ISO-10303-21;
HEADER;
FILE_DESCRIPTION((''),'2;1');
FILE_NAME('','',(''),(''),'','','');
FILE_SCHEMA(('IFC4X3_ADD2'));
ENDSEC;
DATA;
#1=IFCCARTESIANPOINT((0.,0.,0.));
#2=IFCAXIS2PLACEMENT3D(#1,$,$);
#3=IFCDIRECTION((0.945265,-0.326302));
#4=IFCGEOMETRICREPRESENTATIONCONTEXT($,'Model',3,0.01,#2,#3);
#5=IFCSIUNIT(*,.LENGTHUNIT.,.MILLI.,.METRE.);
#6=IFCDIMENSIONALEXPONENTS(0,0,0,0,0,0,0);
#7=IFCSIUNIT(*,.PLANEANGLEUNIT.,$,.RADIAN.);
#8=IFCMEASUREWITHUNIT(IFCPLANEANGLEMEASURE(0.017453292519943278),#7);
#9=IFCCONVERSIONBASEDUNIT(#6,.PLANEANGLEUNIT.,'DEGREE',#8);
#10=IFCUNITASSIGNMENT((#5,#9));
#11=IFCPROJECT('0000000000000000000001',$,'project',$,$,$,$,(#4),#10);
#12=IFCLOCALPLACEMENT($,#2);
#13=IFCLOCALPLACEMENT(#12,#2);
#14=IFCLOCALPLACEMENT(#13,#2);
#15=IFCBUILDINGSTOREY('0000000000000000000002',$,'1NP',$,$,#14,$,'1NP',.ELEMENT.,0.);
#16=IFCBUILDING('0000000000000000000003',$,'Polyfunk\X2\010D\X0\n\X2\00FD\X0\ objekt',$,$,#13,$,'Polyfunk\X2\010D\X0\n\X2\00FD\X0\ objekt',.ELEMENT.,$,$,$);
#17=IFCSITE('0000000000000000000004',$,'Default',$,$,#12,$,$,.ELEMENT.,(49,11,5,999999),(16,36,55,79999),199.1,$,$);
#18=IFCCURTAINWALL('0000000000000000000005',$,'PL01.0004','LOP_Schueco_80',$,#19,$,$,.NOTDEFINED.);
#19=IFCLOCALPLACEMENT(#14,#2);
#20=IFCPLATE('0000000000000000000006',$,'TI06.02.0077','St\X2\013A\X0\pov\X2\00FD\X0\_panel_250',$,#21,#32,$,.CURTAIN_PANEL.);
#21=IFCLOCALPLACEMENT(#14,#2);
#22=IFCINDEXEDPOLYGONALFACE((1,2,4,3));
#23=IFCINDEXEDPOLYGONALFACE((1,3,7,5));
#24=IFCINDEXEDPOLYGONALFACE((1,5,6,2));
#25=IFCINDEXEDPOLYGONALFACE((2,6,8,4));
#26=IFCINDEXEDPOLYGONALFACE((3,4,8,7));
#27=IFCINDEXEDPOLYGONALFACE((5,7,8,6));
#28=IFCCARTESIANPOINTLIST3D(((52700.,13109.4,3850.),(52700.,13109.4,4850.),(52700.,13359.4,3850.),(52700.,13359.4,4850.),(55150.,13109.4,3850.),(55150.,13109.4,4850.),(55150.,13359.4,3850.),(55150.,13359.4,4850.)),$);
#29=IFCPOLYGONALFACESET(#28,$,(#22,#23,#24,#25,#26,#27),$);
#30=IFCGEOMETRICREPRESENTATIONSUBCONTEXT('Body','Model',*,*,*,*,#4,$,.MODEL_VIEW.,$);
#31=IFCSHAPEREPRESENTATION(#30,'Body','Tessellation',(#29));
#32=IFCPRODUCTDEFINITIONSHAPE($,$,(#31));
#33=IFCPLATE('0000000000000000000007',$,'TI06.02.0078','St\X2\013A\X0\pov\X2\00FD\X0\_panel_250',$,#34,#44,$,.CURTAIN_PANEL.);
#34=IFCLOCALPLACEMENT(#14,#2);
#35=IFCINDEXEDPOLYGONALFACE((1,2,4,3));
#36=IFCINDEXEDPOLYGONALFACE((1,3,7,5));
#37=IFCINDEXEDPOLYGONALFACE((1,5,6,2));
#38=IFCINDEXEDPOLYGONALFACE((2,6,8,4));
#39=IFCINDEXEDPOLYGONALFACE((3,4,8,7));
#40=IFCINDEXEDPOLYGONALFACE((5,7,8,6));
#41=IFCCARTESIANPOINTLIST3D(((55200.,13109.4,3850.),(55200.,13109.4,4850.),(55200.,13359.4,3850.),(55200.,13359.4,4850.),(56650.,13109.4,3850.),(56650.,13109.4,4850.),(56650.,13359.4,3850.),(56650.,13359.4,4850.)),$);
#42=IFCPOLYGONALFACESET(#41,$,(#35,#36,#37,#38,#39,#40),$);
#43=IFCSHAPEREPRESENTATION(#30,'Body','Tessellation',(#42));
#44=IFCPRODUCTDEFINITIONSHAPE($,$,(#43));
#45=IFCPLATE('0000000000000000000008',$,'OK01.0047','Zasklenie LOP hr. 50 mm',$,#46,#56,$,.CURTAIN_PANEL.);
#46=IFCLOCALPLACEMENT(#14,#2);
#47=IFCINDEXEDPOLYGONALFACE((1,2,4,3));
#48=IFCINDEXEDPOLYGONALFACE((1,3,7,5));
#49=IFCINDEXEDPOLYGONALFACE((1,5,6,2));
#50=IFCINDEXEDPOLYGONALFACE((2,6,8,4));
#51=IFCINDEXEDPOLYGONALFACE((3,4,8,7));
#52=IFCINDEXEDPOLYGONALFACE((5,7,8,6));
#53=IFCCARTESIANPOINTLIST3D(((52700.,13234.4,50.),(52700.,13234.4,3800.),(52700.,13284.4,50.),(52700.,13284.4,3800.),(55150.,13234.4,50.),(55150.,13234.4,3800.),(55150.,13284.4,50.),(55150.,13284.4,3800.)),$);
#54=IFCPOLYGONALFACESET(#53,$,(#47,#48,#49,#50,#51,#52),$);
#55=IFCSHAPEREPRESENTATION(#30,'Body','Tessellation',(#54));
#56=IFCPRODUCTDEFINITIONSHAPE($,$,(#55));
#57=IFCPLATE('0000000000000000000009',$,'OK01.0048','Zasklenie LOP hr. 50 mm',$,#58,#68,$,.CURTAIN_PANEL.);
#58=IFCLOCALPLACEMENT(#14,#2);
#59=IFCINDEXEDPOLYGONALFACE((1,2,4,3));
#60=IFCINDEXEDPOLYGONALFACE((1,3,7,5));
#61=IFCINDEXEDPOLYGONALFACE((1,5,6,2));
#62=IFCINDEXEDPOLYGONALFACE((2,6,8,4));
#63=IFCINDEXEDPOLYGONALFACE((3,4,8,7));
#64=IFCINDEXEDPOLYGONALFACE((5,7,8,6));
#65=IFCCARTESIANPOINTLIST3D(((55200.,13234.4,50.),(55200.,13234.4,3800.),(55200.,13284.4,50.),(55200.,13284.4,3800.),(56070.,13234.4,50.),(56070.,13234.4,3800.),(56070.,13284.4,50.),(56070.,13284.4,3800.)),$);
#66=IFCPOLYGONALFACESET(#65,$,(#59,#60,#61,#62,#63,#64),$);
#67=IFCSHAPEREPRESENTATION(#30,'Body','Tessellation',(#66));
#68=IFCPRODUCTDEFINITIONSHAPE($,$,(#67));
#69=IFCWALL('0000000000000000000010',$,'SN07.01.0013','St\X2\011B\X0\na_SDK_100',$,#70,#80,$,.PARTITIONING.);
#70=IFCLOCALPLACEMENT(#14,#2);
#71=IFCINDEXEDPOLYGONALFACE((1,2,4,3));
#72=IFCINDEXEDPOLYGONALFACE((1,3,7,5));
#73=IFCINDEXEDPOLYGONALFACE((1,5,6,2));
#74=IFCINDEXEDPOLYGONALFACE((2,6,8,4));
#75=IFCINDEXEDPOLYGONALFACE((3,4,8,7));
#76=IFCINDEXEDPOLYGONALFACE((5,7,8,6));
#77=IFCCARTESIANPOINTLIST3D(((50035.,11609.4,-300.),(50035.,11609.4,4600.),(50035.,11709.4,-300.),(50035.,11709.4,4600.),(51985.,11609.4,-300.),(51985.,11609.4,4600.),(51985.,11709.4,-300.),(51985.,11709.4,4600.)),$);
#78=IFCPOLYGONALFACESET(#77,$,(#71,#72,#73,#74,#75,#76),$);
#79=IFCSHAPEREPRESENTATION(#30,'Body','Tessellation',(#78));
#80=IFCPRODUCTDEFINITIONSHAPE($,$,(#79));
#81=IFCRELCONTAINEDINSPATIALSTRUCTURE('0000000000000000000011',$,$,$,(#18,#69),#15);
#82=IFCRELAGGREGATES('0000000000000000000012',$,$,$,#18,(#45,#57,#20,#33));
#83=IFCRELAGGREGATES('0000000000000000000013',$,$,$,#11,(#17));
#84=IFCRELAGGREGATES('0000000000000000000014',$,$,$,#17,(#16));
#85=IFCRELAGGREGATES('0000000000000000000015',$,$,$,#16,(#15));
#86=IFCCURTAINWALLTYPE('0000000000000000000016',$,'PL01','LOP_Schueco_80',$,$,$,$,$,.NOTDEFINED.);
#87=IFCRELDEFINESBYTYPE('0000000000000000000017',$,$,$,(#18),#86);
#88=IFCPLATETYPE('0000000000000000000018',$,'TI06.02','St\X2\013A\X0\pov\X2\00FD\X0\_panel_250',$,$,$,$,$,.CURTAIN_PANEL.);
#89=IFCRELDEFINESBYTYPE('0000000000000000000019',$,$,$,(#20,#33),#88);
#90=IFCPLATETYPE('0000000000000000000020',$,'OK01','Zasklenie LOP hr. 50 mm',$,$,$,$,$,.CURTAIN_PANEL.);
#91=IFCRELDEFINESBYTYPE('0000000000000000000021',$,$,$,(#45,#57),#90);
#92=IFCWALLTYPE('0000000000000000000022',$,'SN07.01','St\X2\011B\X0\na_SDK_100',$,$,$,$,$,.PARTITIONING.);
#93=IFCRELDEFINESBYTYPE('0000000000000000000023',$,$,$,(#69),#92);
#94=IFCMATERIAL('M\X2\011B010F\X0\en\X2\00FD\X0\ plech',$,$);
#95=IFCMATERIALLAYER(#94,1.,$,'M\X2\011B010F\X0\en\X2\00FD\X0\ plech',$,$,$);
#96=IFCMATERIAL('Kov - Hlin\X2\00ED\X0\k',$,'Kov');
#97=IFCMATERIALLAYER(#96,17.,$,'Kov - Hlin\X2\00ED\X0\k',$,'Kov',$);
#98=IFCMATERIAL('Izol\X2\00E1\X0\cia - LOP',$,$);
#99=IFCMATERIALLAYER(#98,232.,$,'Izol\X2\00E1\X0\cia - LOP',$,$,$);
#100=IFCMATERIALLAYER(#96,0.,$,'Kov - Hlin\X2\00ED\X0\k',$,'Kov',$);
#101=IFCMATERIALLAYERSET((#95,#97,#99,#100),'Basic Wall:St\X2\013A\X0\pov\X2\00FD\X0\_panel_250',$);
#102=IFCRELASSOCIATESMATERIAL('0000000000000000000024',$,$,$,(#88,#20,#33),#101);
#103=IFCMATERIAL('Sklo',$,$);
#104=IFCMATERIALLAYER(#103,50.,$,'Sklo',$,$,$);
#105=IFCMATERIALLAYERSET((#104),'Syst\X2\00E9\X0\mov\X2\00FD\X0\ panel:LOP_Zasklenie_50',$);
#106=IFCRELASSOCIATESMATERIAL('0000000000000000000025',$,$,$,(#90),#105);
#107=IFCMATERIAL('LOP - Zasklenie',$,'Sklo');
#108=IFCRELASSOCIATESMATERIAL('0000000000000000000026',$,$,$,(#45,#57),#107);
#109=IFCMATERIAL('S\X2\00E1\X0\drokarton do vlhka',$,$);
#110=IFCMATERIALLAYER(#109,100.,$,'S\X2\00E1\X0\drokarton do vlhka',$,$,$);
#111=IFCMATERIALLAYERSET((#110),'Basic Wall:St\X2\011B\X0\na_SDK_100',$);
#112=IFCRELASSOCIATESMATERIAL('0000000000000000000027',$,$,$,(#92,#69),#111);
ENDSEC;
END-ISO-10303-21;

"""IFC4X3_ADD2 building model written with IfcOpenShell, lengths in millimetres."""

from ifc_helpers import new_model, entity, si_unit, converted_unit, direction, frame, frame_2d, origin, origin_2d_with_axis, place, context, subcontext, project, spatial, polyline, rectangle, extrude, clip, bounded_halfspace, source, transform, mapped, material, layer, layer_set, layer_usage, type_object, type_shapes, element, aggregate, save


model = new_model("IFC4X3_ADD2")

# Units and contexts
model_context = context("Model", 3, precision=0.01, world=origin(), true_north=direction((0.945265, -0.326302)))
body_context = subcontext(model_context, "Body", "Model", "MODEL_VIEW")
ifc_project = project(units=[si_unit("LENGTHUNIT", "METRE", prefix="MILLI"), converted_unit("PLANEANGLEUNIT", "DEGREE", entity("IfcPlaneAngleMeasure", 0.017453292519943278), si_unit("PLANEANGLEUNIT", "RADIAN"), dimensions=[0, 0, 0, 0, 0, 0, 0])], contexts=[model_context])

# Site, building, storey
site_placement = place(None, origin())
site = spatial("IfcSite", under=ifc_project, at=site_placement, Name="Default", CompositionType="ELEMENT", RefLatitude=(49, 11, 5, 999999), RefLongitude=(16, 36, 55, 79999), RefElevation=199.1)
building_placement = place(site_placement, origin())
building = spatial("IfcBuilding", under=site, at=building_placement, Name="Polyfunkčný objekt", LongName="Polyfunkčný objekt", CompositionType="ELEMENT")
storey_placement = place(building_placement, origin())
storey = spatial("IfcBuildingStorey", under=building, at=storey_placement, Name="1NP", LongName="1NP", CompositionType="ELEMENT", Elevation=0.0)

# Curtain wall, plates
curtain_wall_type = type_object("IfcCurtainWallType", Name="PL01", Description="LOP_Schueco_80", PredefinedType="NOTDEFINED")
curtain_wall_placement = place(storey_placement, origin())
curtain_wall = element("IfcCurtainWall", 1, at=curtain_wall_placement, inside=storey, type_object=curtain_wall_type, Name="PL01.0004", Description="LOP_Schueco_80", PredefinedType="NOTDEFINED")
ifc_material_1 = material(Name="Měďený plech")
ifc_layer_1 = layer(ifc_material_1, 1.0, Name="Měďený plech")
ifc_material_2 = material(Name="Kov - Hliník", Category="Kov")
ifc_layer_2 = layer(ifc_material_2, 17.0, Name="Kov - Hliník", Category="Kov")
ifc_material_3 = material(Name="Izolácia - LOP")
ifc_layer_3 = layer(ifc_material_3, 232.0, Name="Izolácia - LOP")
ifc_layer_4 = layer(ifc_material_2, 0.0, Name="Kov - Hliník", Category="Kov")
ifc_layer_set_1 = layer_set([ifc_layer_1, ifc_layer_2, ifc_layer_3, ifc_layer_4], Name="Basic Wall:Stĺpový_panel_250")
ifc_layer_usage_1 = layer_usage(ifc_layer_set_1, "AXIS2", "NEGATIVE", 125.0)
plate_type_1 = type_object("IfcPlateType", Name="TI06.02", Description="Stĺpový_panel_250", PredefinedType="CURTAIN_PANEL", material=ifc_layer_set_1)
plate_1_placement = place(storey_placement, frame((52700.0, 13234.4, 3850.0)))
plate_1 = element("IfcPlate", 2, at=plate_1_placement, type_object=plate_type_1, material=ifc_layer_usage_1, Name="TI06.02.0077", Description="Stĺpový_panel_250", PredefinedType="CURTAIN_PANEL", context=body_context, shape_type="SweptSolid", body=[
    extrude(rectangle(XDim=250.0, YDim=2450.0, at=origin_2d_with_axis()), frame((1225.0, 0.0, 0.0), z_axis=(0.0, 0.0, 1.0), x_axis=(0.0, 1.0, 0.0)), (0.0, 0.0, 1.0), 1000.0),
])
ifc_layer_usage_2 = layer_usage(ifc_layer_set_1, "AXIS2", "NEGATIVE", 125.0)
plate_2_placement = place(storey_placement, frame((55200.0, 13234.4, 3850.0)))
plate_2 = element("IfcPlate", 3, at=plate_2_placement, type_object=plate_type_1, material=ifc_layer_usage_2, Name="TI06.02.0078", Description="Stĺpový_panel_250", PredefinedType="CURTAIN_PANEL", context=body_context, shape_type="SweptSolid", body=[
    extrude(rectangle(XDim=250.0, YDim=1450.0, at=origin_2d_with_axis()), frame((725.0, 0.0, 0.0), z_axis=(0.0, 0.0, 1.0), x_axis=(0.0, 1.0, 0.0)), (0.0, 0.0, 1.0), 1000.0),
])
ifc_material_4 = material(Name="LOP - Zasklenie", Category="Sklo")
ifc_material_5 = material(Name="Sklo")
ifc_layer_5 = layer(ifc_material_5, 50.0, Name="Sklo")
ifc_layer_set_2 = layer_set([ifc_layer_5], Name="Systémový panel:LOP_Zasklenie_50")
plate_type_2 = type_object("IfcPlateType", Name="OK01", Description="Zasklenie LOP hr. 50 mm", PredefinedType="CURTAIN_PANEL", material=ifc_layer_set_2)
shared_shape_1 = source(origin(), body_context, "Body", "SweptSolid", [
    extrude(rectangle(XDim=3750.0, YDim=2450.0, at=frame_2d((-141.7, 0.0), x_axis=(1.0, 0.0))), frame((0.0, 0.0, 2016.7), z_axis=(0.0, 1.0, 0.0), x_axis=(0.0, 0.0, 1.0)), (0.0, 0.0, 1.0), 50.0),
])
plate_3_placement = place(curtain_wall_placement, frame((53925.0, 13234.4, 50.0)))
plate_3 = element("IfcPlate", 4, at=plate_3_placement, type_object=plate_type_2, material=ifc_material_4, Name="OK01.0047", Description="Zasklenie LOP hr. 50 mm", PredefinedType="CURTAIN_PANEL", context=body_context, shape_type="MappedRepresentation", body=[
    mapped(shared_shape_1, transform((0.0, 0.0, 0.0), scale=1.0)),
])
shared_shape_2 = source(origin(), body_context, "Body", "SweptSolid", [
    extrude(rectangle(XDim=3750.0, YDim=870.0, at=frame_2d((-141.7, 0.0), x_axis=(1.0, 0.0))), frame((0.0, 0.0, 2016.7), z_axis=(0.0, 1.0, 0.0), x_axis=(0.0, 0.0, 1.0)), (0.0, 0.0, 1.0), 50.0),
])
type_shapes(plate_type_2, [shared_shape_1, shared_shape_2])
plate_4_placement = place(curtain_wall_placement, frame((55635.0, 13234.4, 50.0)))
plate_4 = element("IfcPlate", 5, at=plate_4_placement, type_object=plate_type_2, material=ifc_material_4, Name="OK01.0048", Description="Zasklenie LOP hr. 50 mm", PredefinedType="CURTAIN_PANEL", context=body_context, shape_type="MappedRepresentation", body=[
    mapped(shared_shape_2, transform((0.0, 0.0, 0.0), scale=1.0)),
])
aggregate(curtain_wall, [plate_3, plate_4, plate_1, plate_2])

# Wall
ifc_material_6 = material(Name="Sádrokarton do vlhka")
ifc_layer_6 = layer(ifc_material_6, 100.0, Name="Sádrokarton do vlhka")
ifc_layer_set_3 = layer_set([ifc_layer_6], Name="Basic Wall:Stěna_SDK_100")
wall_type = type_object("IfcWallType", Name="SN07.01", Description="Stěna_SDK_100", PredefinedType="PARTITIONING", material=ifc_layer_set_3)
wall_placement = place(storey_placement, frame((51985.0, 11659.4, -300.0), z_axis=(0.0, 0.0, 1.0), x_axis=(-1.0, 0.0, 0.0)))
element("IfcWall", 6, at=wall_placement, inside=storey, type_object=wall_type, material=ifc_layer_set_3, Name="SN07.01.0013", Description="Stěna_SDK_100", PredefinedType="PARTITIONING", context=body_context, shape_type="Clipping", body=[
    clip(clip(extrude(rectangle(XDim=1950.0, YDim=100.0, at=frame_2d((975.0, 0.0), x_axis=(-1.0, 0.0))), origin(), (0.0, 0.0, 1.0), 4900.0), bounded_halfspace(frame((0.0, -50.0, 4900.0), z_axis=(0.0, 0.0, -1.0), x_axis=(-1.0, 0.0, 0.0)), True, frame((0.0, -50.0, 4900.0)), polyline([(0.0, 0.0), (1950.0, 0.0), (1950.0, 100.0), (1050.0, 100.0), (900.0, 100.0), (0.0, 100.0), (0.0, 0.0)]))), bounded_halfspace(frame((1950.0, -50.0, 0.0), z_axis=(0.0, 0.0, 1.0), x_axis=(0.0, -1.0, 0.0)), True, frame((1950.0, -50.0, 0.0)), polyline([(0.0, 0.0), (0.0, 100.0), (-900.0, 100.0), (-1050.0, 100.0), (-1950.0, 100.0), (-1950.0, 0.0), (0.0, 0.0)]))),
])

save(model, "model.ifc")
